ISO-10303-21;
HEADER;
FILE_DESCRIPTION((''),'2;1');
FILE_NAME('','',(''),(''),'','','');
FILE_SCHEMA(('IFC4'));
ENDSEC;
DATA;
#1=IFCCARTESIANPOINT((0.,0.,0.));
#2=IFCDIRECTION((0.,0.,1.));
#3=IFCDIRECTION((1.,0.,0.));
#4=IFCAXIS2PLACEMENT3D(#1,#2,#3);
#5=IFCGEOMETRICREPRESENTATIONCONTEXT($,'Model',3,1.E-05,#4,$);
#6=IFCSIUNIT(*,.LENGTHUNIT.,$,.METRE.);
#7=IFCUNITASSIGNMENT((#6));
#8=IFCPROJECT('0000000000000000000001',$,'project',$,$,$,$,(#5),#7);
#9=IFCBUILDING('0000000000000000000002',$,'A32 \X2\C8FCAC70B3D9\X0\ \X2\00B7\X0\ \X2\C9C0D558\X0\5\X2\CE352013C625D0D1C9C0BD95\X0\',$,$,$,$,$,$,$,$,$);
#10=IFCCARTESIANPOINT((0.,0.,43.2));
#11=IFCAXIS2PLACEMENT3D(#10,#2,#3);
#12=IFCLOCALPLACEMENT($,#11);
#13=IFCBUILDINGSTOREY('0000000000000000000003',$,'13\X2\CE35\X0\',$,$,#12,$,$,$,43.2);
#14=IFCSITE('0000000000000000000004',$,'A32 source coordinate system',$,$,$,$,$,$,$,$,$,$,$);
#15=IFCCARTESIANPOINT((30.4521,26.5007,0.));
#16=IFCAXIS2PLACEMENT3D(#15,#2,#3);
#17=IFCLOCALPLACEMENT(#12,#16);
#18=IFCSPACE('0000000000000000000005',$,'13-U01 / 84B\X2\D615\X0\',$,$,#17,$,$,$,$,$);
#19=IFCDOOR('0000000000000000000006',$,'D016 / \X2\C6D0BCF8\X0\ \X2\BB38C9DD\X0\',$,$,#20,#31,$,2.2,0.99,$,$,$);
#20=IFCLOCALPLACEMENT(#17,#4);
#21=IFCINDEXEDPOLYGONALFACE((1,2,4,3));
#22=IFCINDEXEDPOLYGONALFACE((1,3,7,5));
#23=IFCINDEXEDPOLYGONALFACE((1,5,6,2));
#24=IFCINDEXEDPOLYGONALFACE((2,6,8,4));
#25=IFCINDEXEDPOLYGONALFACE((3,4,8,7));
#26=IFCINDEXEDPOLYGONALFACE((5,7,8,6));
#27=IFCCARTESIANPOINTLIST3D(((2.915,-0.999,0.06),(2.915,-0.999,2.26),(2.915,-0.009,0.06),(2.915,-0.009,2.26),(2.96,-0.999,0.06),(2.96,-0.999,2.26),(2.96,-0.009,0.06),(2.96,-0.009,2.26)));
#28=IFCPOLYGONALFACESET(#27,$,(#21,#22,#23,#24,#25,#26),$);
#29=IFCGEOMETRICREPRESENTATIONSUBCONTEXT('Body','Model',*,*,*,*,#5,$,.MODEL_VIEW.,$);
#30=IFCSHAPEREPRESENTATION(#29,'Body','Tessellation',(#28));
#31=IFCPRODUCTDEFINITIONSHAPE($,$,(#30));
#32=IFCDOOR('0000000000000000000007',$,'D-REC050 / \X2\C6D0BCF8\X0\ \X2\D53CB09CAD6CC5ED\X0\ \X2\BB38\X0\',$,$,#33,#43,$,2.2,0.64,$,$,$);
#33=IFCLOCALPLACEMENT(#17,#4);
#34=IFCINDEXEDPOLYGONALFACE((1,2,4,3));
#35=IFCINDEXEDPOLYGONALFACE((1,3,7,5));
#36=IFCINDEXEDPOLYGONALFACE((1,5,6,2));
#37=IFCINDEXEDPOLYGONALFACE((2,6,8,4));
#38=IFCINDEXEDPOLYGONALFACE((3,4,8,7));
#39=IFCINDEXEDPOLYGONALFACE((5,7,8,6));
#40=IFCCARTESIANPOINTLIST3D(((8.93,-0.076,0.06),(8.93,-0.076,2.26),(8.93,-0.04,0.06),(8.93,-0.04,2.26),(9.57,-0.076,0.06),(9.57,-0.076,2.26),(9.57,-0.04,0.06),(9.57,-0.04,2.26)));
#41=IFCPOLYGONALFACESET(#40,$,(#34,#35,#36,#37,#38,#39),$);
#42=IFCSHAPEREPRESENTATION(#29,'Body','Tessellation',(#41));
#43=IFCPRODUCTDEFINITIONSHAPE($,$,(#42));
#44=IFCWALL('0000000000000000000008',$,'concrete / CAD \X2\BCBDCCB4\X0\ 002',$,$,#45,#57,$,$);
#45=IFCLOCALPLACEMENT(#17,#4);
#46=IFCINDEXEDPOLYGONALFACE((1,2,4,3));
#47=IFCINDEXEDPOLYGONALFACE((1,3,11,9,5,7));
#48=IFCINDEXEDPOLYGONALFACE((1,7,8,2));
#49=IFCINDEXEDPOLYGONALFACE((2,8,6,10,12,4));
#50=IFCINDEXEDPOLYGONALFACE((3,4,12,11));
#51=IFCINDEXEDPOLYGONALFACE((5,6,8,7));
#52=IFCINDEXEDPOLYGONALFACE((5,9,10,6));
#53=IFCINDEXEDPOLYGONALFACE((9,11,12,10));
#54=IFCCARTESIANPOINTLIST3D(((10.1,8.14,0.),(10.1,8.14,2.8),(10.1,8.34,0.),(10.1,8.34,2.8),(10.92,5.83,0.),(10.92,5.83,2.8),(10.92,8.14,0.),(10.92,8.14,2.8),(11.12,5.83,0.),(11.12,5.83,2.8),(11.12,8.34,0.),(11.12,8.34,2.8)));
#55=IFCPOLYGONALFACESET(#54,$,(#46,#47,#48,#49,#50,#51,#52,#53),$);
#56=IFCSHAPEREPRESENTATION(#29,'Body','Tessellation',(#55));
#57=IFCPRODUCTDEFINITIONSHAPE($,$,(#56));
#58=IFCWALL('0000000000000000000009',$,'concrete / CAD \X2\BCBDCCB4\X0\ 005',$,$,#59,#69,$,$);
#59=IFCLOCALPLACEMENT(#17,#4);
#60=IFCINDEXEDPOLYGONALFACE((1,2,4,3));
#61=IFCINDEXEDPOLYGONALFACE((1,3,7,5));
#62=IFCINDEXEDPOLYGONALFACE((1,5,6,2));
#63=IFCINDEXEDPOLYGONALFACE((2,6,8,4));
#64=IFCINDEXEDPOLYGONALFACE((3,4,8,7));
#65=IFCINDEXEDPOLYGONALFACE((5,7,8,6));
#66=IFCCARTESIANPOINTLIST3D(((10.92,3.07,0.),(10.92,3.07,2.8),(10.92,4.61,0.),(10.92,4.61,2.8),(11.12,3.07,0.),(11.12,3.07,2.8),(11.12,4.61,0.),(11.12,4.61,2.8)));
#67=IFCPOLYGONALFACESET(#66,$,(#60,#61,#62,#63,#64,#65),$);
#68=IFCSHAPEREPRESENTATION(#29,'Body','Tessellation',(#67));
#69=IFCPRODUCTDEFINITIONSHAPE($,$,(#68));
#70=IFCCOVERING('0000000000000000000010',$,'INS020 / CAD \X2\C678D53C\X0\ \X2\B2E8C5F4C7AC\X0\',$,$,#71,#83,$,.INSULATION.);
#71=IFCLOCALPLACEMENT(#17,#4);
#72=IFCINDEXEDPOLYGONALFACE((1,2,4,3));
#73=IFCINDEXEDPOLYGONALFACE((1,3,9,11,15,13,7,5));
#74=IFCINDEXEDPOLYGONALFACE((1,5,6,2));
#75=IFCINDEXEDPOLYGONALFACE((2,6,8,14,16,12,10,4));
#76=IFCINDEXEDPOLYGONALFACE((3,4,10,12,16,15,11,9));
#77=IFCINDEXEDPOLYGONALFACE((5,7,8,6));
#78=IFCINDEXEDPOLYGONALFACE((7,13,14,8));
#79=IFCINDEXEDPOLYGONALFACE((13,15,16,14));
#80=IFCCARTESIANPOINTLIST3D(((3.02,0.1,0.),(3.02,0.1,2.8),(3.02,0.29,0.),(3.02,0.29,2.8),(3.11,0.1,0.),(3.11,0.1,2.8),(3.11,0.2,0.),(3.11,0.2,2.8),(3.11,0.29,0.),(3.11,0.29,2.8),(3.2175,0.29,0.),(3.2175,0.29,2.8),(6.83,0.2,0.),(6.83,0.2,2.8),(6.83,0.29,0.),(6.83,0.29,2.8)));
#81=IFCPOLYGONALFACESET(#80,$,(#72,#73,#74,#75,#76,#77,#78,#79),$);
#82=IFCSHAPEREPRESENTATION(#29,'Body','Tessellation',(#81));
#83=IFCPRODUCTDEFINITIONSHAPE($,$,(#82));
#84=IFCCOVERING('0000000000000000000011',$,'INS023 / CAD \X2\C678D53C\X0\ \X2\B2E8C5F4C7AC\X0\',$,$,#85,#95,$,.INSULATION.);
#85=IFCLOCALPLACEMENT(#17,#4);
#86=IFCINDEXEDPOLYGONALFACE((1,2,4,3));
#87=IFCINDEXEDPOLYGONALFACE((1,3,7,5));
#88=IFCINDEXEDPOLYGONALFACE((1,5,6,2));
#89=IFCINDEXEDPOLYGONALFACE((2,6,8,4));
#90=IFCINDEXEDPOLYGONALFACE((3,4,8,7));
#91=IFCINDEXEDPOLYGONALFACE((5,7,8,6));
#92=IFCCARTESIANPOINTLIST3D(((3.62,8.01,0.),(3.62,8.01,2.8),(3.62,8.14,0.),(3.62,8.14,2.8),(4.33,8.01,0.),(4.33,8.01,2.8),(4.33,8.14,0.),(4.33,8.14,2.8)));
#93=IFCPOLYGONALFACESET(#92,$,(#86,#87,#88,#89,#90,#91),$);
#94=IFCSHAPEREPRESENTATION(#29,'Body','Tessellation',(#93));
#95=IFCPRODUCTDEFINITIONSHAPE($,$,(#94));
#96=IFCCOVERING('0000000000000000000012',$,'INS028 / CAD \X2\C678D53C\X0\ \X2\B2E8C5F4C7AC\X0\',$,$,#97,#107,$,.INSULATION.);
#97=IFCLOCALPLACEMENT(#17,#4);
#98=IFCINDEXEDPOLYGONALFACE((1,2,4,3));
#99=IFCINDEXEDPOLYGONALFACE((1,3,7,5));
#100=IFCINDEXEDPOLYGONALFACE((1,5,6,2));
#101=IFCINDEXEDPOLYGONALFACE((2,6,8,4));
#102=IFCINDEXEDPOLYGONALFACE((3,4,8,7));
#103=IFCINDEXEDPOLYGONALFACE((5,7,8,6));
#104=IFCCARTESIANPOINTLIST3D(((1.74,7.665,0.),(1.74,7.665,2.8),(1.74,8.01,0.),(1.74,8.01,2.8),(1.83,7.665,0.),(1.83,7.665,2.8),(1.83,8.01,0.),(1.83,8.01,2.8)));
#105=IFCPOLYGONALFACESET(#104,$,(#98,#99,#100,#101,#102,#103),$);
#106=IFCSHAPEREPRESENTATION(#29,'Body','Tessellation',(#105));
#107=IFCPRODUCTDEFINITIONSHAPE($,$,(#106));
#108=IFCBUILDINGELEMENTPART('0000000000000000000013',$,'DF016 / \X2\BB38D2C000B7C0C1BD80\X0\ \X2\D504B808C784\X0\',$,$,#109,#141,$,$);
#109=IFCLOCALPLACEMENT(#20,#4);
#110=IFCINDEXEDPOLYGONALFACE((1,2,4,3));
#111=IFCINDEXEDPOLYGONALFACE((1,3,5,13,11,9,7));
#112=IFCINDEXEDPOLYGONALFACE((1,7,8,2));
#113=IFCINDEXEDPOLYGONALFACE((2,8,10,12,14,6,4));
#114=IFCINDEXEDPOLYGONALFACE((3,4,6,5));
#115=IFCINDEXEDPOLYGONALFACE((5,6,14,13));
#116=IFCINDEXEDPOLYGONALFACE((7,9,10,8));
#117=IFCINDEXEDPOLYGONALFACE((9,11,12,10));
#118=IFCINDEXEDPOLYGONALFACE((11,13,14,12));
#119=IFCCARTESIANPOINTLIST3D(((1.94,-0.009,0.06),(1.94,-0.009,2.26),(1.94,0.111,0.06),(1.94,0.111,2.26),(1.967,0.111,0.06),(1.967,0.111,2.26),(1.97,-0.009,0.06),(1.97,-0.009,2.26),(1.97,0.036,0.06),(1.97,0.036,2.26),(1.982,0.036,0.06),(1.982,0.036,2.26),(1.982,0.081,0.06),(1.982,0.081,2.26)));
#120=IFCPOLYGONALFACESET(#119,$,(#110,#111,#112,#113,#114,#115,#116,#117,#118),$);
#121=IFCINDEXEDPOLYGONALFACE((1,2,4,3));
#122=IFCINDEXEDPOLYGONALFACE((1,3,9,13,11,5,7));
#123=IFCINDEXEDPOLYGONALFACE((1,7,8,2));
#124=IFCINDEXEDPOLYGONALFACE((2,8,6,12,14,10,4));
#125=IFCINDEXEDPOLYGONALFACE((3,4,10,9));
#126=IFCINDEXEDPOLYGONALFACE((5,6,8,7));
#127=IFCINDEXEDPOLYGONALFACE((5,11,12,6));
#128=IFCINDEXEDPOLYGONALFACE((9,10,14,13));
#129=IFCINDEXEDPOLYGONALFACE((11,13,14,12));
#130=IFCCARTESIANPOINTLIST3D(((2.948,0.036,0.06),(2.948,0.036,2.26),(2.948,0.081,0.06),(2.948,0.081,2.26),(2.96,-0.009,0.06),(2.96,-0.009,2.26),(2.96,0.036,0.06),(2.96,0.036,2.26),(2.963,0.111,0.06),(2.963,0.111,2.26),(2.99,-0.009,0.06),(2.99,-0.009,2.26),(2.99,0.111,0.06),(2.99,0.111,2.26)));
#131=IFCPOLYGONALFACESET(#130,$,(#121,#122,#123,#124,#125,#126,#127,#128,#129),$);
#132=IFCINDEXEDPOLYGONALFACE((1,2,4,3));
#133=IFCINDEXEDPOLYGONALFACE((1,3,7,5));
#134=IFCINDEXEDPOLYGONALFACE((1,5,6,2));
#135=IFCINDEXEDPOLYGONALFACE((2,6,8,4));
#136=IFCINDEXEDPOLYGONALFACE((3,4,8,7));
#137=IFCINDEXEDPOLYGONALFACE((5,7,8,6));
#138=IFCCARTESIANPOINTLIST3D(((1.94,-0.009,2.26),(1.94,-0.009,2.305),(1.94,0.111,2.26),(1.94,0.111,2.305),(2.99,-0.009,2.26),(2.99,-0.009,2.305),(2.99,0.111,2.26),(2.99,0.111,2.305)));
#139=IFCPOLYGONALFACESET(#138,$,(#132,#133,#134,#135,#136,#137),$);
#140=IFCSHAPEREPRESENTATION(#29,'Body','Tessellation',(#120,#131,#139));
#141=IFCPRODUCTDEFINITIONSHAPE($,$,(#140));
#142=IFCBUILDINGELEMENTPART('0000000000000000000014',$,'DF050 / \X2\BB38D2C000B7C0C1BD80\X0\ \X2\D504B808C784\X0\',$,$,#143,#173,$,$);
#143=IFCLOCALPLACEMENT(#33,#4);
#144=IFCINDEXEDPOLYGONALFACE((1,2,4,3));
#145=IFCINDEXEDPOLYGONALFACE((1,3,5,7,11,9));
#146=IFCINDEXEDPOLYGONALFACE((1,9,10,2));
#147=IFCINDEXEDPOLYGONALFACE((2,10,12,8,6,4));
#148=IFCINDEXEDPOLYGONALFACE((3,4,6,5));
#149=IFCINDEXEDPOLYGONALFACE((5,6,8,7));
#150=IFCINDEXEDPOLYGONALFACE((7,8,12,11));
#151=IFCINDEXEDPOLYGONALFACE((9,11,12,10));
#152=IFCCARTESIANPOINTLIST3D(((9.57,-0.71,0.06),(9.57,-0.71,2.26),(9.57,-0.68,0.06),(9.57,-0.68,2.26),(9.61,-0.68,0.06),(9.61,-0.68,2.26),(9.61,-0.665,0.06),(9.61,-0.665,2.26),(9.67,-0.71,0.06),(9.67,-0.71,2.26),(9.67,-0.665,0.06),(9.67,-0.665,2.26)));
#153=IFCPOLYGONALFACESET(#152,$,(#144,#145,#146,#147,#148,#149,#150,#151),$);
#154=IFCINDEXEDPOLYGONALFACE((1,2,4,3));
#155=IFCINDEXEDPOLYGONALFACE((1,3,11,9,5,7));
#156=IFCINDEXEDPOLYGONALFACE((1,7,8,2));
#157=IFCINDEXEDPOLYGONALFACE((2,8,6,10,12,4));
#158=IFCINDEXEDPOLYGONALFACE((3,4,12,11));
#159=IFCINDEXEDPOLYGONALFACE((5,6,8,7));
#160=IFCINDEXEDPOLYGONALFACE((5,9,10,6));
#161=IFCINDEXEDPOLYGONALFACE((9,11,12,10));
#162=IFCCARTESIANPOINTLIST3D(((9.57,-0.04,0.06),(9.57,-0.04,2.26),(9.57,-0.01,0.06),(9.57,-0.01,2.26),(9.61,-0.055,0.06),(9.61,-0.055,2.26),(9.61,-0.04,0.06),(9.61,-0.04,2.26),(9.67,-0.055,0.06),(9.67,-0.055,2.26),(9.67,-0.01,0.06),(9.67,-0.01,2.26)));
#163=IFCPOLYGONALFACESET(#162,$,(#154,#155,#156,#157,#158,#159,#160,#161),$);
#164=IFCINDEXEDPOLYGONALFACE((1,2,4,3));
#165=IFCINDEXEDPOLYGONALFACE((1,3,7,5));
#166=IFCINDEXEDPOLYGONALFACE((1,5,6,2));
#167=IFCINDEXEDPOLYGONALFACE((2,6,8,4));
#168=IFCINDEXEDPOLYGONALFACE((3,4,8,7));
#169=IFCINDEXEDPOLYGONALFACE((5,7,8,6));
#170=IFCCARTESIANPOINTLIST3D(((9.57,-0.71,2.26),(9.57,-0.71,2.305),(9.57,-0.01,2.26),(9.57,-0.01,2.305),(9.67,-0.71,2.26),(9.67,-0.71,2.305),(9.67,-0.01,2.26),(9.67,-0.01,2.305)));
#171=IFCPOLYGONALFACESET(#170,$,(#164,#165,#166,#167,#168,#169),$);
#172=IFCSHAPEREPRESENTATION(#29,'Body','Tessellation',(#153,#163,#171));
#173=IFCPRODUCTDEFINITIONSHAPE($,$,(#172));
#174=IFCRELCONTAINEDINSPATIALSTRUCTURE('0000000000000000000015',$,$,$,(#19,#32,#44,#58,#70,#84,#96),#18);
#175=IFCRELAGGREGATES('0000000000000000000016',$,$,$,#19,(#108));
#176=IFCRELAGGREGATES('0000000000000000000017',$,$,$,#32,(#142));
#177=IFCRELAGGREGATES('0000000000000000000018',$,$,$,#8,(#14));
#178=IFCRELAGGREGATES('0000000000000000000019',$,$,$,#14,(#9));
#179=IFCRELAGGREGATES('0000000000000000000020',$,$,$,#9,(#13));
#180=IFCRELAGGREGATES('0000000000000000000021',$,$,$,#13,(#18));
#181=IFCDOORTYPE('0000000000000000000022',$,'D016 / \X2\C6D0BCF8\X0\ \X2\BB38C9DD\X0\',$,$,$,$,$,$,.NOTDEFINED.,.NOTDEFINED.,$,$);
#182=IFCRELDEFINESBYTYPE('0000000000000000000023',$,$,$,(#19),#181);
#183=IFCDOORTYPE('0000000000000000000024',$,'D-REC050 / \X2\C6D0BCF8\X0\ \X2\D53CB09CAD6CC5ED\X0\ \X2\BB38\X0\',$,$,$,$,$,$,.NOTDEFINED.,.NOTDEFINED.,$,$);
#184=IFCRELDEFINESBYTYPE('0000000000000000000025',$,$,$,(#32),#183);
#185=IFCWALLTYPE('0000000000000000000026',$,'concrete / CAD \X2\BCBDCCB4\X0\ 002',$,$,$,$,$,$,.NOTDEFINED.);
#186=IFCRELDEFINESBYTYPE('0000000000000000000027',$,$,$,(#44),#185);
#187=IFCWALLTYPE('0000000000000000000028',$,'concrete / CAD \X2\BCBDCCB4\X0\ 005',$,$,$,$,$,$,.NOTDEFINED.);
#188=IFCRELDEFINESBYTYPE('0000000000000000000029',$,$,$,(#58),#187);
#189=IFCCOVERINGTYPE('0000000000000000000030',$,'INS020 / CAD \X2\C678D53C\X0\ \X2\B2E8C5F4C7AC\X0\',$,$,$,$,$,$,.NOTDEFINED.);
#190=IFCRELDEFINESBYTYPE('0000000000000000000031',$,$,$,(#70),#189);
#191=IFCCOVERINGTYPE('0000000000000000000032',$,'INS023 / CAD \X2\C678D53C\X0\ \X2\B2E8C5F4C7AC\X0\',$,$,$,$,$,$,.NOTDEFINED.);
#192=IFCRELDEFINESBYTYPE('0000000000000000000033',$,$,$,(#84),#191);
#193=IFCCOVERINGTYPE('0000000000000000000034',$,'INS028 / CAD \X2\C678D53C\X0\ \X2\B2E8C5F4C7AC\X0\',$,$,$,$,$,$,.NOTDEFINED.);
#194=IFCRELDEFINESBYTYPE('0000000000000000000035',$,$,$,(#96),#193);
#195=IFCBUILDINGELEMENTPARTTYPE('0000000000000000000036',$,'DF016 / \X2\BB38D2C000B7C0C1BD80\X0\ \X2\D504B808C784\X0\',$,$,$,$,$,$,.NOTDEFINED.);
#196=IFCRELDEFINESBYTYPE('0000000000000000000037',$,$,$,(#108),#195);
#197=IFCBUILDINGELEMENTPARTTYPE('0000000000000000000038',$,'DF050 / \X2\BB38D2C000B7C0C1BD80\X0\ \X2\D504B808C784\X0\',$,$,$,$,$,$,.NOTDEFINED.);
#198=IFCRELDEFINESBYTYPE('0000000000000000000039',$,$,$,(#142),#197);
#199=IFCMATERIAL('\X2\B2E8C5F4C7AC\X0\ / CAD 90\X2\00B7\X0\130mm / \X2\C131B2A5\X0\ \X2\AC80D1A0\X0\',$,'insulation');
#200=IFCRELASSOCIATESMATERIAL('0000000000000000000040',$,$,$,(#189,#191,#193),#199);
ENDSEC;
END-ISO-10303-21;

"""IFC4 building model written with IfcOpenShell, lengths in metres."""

from ifc_helpers import new_model, si_unit, frame, origin, origin_with_axes, place, context, subcontext, project, spatial, polyline, outline, extrude, source, transform, mapped, material, type_object, type_shapes, element, aggregate, save


model = new_model("IFC4")

# Units and contexts
model_context = context("Model", 3, precision=1e-05, world=origin_with_axes())
body_context = subcontext(model_context, "Body", "Model", "MODEL_VIEW")
ifc_project = project(units=[si_unit("LENGTHUNIT", "METRE")], contexts=[model_context])

# Site, building, storey, space
storey_placement = place(None, frame((0.0, 0.0, 43.2), z_axis=(0.0, 0.0, 1.0), x_axis=(1.0, 0.0, 0.0)))
space_placement = place(storey_placement, frame((30.4521, 26.5007, 0.0), z_axis=(0.0, 0.0, 1.0), x_axis=(1.0, 0.0, 0.0)))
site = spatial("IfcSite", under=ifc_project, Name="A32 source coordinate system")
building = spatial("IfcBuilding", under=site, Name="A32 주거동 · 지하5층–옥탑지붕")
storey = spatial("IfcBuildingStorey", under=building, at=storey_placement, Name="13층", Elevation=43.2)
space = spatial("IfcSpace", under=storey, at=space_placement, Name="13-U01 / 84B형")

# Doors
door_type_1 = type_object("IfcDoorType", Name="D016 / 원본 문짝", OperationType="NOTDEFINED", PredefinedType="NOTDEFINED")
shared_shape_1 = source(origin(), body_context, "Body", "SweptSolid", [
    extrude(outline(polyline([(2.96, -0.009), (2.96, -0.999), (2.915, -0.999), (2.915, -0.009), (2.96, -0.009)])), frame((0.0, 0.0, 0.06)), (0.0, 0.0, 1.0), 2.2),
])
type_shapes(door_type_1, [shared_shape_1])
door_1_placement = place(space_placement, origin_with_axes())
door_1 = element("IfcDoor", 1, at=door_1_placement, inside=space, type_object=door_type_1, Name="D016 / 원본 문짝", OverallHeight=2.2, OverallWidth=0.99, context=body_context, shape_type="MappedRepresentation", body=[
    mapped(shared_shape_1, transform((0.0, 0.0, 0.0), scale=1.0)),
])
door_type_2 = type_object("IfcDoorType", Name="D-REC050 / 원본 피난구역 문", OperationType="NOTDEFINED", PredefinedType="NOTDEFINED")
shared_shape_2 = source(origin(), body_context, "Body", "SweptSolid", [
    extrude(outline(polyline([(9.57, -0.04), (9.57, -0.076), (8.93, -0.076), (8.93, -0.04), (9.57, -0.04)])), frame((0.0, 0.0, 0.06)), (0.0, 0.0, 1.0), 2.2),
])
type_shapes(door_type_2, [shared_shape_2])
door_2_placement = place(space_placement, origin_with_axes())
door_2 = element("IfcDoor", 2, at=door_2_placement, inside=space, type_object=door_type_2, Name="D-REC050 / 원본 피난구역 문", OverallHeight=2.2, OverallWidth=0.64, context=body_context, shape_type="MappedRepresentation", body=[
    mapped(shared_shape_2, transform((0.0, 0.0, 0.0), scale=1.0)),
])

# Walls
wall_type_1 = type_object("IfcWallType", Name="concrete / CAD 벽체 002", PredefinedType="NOTDEFINED")
shared_shape_3 = source(origin(), body_context, "Body", "SweptSolid", [
    extrude(outline(polyline([(11.12, 5.83), (10.92, 5.83), (10.92, 8.14), (10.1, 8.14), (10.1, 8.34), (11.12, 8.34), (11.12, 5.83)])), origin(), (0.0, 0.0, 1.0), 2.8),
])
type_shapes(wall_type_1, [shared_shape_3])
wall_1_placement = place(space_placement, origin_with_axes())
element("IfcWall", 3, at=wall_1_placement, inside=space, type_object=wall_type_1, Name="concrete / CAD 벽체 002", context=body_context, shape_type="MappedRepresentation", body=[
    mapped(shared_shape_3, transform((0.0, 0.0, 0.0), scale=1.0)),
])
wall_type_2 = type_object("IfcWallType", Name="concrete / CAD 벽체 005", PredefinedType="NOTDEFINED")
shared_shape_4 = source(origin(), body_context, "Body", "SweptSolid", [
    extrude(outline(polyline([(11.12, 3.07), (10.92, 3.07), (10.92, 4.61), (11.12, 4.61), (11.12, 3.07)])), origin(), (0.0, 0.0, 1.0), 2.8),
])
type_shapes(wall_type_2, [shared_shape_4])
wall_2_placement = place(space_placement, origin_with_axes())
element("IfcWall", 4, at=wall_2_placement, inside=space, type_object=wall_type_2, Name="concrete / CAD 벽체 005", context=body_context, shape_type="MappedRepresentation", body=[
    mapped(shared_shape_4, transform((0.0, 0.0, 0.0), scale=1.0)),
])

# Coverings
ifc_material = material(Name="단열재 / CAD 90·130mm / 성능 검토", Category="insulation")
covering_type_1 = type_object("IfcCoveringType", Name="INS020 / CAD 외피 단열재", PredefinedType="NOTDEFINED", material=ifc_material)
shared_shape_5 = source(origin(), body_context, "Body", "SweptSolid", [
    extrude(outline(polyline([(3.11, 0.2), (3.11, 0.1), (3.02, 0.1), (3.02, 0.29), (3.11, 0.29), (3.2175, 0.29), (6.83, 0.29), (6.83, 0.2), (3.11, 0.2)])), origin(), (0.0, 0.0, 1.0), 2.8),
])
type_shapes(covering_type_1, [shared_shape_5])
covering_1_placement = place(space_placement, origin_with_axes())
element("IfcCovering", 5, at=covering_1_placement, inside=space, type_object=covering_type_1, Name="INS020 / CAD 외피 단열재", PredefinedType="INSULATION", context=body_context, shape_type="MappedRepresentation", body=[
    mapped(shared_shape_5, transform((0.0, 0.0, 0.0), scale=1.0)),
])
covering_type_2 = type_object("IfcCoveringType", Name="INS023 / CAD 외피 단열재", PredefinedType="NOTDEFINED", material=ifc_material)
shared_shape_6 = source(origin(), body_context, "Body", "SweptSolid", [
    extrude(outline(polyline([(4.33, 8.01), (3.62, 8.01), (3.62, 8.14), (4.33, 8.14), (4.33, 8.01)])), origin(), (0.0, 0.0, 1.0), 2.8),
])
type_shapes(covering_type_2, [shared_shape_6])
covering_2_placement = place(space_placement, origin_with_axes())
element("IfcCovering", 6, at=covering_2_placement, inside=space, type_object=covering_type_2, Name="INS023 / CAD 외피 단열재", PredefinedType="INSULATION", context=body_context, shape_type="MappedRepresentation", body=[
    mapped(shared_shape_6, transform((0.0, 0.0, 0.0), scale=1.0)),
])
covering_type_3 = type_object("IfcCoveringType", Name="INS028 / CAD 외피 단열재", PredefinedType="NOTDEFINED", material=ifc_material)
shared_shape_7 = source(origin(), body_context, "Body", "SweptSolid", [
    extrude(outline(polyline([(1.74, 8.01), (1.83, 8.01), (1.83, 7.665), (1.74, 7.665), (1.74, 8.01)])), origin(), (0.0, 0.0, 1.0), 2.8),
])
type_shapes(covering_type_3, [shared_shape_7])
covering_3_placement = place(space_placement, origin_with_axes())
element("IfcCovering", 7, at=covering_3_placement, inside=space, type_object=covering_type_3, Name="INS028 / CAD 외피 단열재", PredefinedType="INSULATION", context=body_context, shape_type="MappedRepresentation", body=[
    mapped(shared_shape_7, transform((0.0, 0.0, 0.0), scale=1.0)),
])

# Building element parts
building_element_part_type_1 = type_object("IfcBuildingElementPartType", Name="DF016 / 문틀·상부 프레임", PredefinedType="NOTDEFINED")
shared_shape_8 = source(origin(), body_context, "Body", "SweptSolid", [
    extrude(outline(polyline([(1.94, 0.111), (1.967, 0.111), (1.982, 0.081), (1.982, 0.036), (1.97, 0.036), (1.97, -0.009), (1.94, -0.009), (1.94, 0.111)])), frame((0.0, 0.0, 0.06)), (0.0, 0.0, 1.0), 2.2),
    extrude(outline(polyline([(2.96, -0.009), (2.96, 0.036), (2.948, 0.036), (2.948, 0.081), (2.963, 0.111), (2.99, 0.111), (2.99, -0.009), (2.96, -0.009)])), frame((0.0, 0.0, 0.06)), (0.0, 0.0, 1.0), 2.2),
    extrude(outline(polyline([(1.94, -0.009), (1.94, 0.111), (2.99, 0.111), (2.99, -0.009), (1.94, -0.009)])), frame((0.0, 0.0, 2.26)), (0.0, 0.0, 1.0), 0.045),
])
type_shapes(building_element_part_type_1, [shared_shape_8])
building_element_part_1_placement = place(door_1_placement, origin_with_axes())
building_element_part_1 = element("IfcBuildingElementPart", 8, at=building_element_part_1_placement, type_object=building_element_part_type_1, Name="DF016 / 문틀·상부 프레임", context=body_context, shape_type="MappedRepresentation", body=[
    mapped(shared_shape_8, transform((0.0, 0.0, 0.0), scale=1.0)),
])
aggregate(door_1, [building_element_part_1])
building_element_part_type_2 = type_object("IfcBuildingElementPartType", Name="DF050 / 문틀·상부 프레임", PredefinedType="NOTDEFINED")
shared_shape_9 = source(origin(), body_context, "Body", "SweptSolid", [
    extrude(outline(polyline([(9.57, -0.68), (9.61, -0.68), (9.61, -0.665), (9.67, -0.665), (9.67, -0.71), (9.57, -0.71), (9.57, -0.68)])), frame((0.0, 0.0, 0.06)), (0.0, 0.0, 1.0), 2.2),
    extrude(outline(polyline([(9.67, -0.01), (9.67, -0.055), (9.61, -0.055), (9.61, -0.04), (9.57, -0.04), (9.57, -0.01), (9.67, -0.01)])), frame((0.0, 0.0, 0.06)), (0.0, 0.0, 1.0), 2.2),
    extrude(outline(polyline([(9.57, -0.71), (9.57, -0.01), (9.67, -0.01), (9.67, -0.71), (9.57, -0.71)])), frame((0.0, 0.0, 2.26)), (0.0, 0.0, 1.0), 0.045),
])
type_shapes(building_element_part_type_2, [shared_shape_9])
building_element_part_2_placement = place(door_2_placement, origin_with_axes())
building_element_part_2 = element("IfcBuildingElementPart", 9, at=building_element_part_2_placement, type_object=building_element_part_type_2, Name="DF050 / 문틀·상부 프레임", context=body_context, shape_type="MappedRepresentation", body=[
    mapped(shared_shape_9, transform((0.0, 0.0, 0.0), scale=1.0)),
])
aggregate(door_2, [building_element_part_2])

save(model, "model.ifc")
